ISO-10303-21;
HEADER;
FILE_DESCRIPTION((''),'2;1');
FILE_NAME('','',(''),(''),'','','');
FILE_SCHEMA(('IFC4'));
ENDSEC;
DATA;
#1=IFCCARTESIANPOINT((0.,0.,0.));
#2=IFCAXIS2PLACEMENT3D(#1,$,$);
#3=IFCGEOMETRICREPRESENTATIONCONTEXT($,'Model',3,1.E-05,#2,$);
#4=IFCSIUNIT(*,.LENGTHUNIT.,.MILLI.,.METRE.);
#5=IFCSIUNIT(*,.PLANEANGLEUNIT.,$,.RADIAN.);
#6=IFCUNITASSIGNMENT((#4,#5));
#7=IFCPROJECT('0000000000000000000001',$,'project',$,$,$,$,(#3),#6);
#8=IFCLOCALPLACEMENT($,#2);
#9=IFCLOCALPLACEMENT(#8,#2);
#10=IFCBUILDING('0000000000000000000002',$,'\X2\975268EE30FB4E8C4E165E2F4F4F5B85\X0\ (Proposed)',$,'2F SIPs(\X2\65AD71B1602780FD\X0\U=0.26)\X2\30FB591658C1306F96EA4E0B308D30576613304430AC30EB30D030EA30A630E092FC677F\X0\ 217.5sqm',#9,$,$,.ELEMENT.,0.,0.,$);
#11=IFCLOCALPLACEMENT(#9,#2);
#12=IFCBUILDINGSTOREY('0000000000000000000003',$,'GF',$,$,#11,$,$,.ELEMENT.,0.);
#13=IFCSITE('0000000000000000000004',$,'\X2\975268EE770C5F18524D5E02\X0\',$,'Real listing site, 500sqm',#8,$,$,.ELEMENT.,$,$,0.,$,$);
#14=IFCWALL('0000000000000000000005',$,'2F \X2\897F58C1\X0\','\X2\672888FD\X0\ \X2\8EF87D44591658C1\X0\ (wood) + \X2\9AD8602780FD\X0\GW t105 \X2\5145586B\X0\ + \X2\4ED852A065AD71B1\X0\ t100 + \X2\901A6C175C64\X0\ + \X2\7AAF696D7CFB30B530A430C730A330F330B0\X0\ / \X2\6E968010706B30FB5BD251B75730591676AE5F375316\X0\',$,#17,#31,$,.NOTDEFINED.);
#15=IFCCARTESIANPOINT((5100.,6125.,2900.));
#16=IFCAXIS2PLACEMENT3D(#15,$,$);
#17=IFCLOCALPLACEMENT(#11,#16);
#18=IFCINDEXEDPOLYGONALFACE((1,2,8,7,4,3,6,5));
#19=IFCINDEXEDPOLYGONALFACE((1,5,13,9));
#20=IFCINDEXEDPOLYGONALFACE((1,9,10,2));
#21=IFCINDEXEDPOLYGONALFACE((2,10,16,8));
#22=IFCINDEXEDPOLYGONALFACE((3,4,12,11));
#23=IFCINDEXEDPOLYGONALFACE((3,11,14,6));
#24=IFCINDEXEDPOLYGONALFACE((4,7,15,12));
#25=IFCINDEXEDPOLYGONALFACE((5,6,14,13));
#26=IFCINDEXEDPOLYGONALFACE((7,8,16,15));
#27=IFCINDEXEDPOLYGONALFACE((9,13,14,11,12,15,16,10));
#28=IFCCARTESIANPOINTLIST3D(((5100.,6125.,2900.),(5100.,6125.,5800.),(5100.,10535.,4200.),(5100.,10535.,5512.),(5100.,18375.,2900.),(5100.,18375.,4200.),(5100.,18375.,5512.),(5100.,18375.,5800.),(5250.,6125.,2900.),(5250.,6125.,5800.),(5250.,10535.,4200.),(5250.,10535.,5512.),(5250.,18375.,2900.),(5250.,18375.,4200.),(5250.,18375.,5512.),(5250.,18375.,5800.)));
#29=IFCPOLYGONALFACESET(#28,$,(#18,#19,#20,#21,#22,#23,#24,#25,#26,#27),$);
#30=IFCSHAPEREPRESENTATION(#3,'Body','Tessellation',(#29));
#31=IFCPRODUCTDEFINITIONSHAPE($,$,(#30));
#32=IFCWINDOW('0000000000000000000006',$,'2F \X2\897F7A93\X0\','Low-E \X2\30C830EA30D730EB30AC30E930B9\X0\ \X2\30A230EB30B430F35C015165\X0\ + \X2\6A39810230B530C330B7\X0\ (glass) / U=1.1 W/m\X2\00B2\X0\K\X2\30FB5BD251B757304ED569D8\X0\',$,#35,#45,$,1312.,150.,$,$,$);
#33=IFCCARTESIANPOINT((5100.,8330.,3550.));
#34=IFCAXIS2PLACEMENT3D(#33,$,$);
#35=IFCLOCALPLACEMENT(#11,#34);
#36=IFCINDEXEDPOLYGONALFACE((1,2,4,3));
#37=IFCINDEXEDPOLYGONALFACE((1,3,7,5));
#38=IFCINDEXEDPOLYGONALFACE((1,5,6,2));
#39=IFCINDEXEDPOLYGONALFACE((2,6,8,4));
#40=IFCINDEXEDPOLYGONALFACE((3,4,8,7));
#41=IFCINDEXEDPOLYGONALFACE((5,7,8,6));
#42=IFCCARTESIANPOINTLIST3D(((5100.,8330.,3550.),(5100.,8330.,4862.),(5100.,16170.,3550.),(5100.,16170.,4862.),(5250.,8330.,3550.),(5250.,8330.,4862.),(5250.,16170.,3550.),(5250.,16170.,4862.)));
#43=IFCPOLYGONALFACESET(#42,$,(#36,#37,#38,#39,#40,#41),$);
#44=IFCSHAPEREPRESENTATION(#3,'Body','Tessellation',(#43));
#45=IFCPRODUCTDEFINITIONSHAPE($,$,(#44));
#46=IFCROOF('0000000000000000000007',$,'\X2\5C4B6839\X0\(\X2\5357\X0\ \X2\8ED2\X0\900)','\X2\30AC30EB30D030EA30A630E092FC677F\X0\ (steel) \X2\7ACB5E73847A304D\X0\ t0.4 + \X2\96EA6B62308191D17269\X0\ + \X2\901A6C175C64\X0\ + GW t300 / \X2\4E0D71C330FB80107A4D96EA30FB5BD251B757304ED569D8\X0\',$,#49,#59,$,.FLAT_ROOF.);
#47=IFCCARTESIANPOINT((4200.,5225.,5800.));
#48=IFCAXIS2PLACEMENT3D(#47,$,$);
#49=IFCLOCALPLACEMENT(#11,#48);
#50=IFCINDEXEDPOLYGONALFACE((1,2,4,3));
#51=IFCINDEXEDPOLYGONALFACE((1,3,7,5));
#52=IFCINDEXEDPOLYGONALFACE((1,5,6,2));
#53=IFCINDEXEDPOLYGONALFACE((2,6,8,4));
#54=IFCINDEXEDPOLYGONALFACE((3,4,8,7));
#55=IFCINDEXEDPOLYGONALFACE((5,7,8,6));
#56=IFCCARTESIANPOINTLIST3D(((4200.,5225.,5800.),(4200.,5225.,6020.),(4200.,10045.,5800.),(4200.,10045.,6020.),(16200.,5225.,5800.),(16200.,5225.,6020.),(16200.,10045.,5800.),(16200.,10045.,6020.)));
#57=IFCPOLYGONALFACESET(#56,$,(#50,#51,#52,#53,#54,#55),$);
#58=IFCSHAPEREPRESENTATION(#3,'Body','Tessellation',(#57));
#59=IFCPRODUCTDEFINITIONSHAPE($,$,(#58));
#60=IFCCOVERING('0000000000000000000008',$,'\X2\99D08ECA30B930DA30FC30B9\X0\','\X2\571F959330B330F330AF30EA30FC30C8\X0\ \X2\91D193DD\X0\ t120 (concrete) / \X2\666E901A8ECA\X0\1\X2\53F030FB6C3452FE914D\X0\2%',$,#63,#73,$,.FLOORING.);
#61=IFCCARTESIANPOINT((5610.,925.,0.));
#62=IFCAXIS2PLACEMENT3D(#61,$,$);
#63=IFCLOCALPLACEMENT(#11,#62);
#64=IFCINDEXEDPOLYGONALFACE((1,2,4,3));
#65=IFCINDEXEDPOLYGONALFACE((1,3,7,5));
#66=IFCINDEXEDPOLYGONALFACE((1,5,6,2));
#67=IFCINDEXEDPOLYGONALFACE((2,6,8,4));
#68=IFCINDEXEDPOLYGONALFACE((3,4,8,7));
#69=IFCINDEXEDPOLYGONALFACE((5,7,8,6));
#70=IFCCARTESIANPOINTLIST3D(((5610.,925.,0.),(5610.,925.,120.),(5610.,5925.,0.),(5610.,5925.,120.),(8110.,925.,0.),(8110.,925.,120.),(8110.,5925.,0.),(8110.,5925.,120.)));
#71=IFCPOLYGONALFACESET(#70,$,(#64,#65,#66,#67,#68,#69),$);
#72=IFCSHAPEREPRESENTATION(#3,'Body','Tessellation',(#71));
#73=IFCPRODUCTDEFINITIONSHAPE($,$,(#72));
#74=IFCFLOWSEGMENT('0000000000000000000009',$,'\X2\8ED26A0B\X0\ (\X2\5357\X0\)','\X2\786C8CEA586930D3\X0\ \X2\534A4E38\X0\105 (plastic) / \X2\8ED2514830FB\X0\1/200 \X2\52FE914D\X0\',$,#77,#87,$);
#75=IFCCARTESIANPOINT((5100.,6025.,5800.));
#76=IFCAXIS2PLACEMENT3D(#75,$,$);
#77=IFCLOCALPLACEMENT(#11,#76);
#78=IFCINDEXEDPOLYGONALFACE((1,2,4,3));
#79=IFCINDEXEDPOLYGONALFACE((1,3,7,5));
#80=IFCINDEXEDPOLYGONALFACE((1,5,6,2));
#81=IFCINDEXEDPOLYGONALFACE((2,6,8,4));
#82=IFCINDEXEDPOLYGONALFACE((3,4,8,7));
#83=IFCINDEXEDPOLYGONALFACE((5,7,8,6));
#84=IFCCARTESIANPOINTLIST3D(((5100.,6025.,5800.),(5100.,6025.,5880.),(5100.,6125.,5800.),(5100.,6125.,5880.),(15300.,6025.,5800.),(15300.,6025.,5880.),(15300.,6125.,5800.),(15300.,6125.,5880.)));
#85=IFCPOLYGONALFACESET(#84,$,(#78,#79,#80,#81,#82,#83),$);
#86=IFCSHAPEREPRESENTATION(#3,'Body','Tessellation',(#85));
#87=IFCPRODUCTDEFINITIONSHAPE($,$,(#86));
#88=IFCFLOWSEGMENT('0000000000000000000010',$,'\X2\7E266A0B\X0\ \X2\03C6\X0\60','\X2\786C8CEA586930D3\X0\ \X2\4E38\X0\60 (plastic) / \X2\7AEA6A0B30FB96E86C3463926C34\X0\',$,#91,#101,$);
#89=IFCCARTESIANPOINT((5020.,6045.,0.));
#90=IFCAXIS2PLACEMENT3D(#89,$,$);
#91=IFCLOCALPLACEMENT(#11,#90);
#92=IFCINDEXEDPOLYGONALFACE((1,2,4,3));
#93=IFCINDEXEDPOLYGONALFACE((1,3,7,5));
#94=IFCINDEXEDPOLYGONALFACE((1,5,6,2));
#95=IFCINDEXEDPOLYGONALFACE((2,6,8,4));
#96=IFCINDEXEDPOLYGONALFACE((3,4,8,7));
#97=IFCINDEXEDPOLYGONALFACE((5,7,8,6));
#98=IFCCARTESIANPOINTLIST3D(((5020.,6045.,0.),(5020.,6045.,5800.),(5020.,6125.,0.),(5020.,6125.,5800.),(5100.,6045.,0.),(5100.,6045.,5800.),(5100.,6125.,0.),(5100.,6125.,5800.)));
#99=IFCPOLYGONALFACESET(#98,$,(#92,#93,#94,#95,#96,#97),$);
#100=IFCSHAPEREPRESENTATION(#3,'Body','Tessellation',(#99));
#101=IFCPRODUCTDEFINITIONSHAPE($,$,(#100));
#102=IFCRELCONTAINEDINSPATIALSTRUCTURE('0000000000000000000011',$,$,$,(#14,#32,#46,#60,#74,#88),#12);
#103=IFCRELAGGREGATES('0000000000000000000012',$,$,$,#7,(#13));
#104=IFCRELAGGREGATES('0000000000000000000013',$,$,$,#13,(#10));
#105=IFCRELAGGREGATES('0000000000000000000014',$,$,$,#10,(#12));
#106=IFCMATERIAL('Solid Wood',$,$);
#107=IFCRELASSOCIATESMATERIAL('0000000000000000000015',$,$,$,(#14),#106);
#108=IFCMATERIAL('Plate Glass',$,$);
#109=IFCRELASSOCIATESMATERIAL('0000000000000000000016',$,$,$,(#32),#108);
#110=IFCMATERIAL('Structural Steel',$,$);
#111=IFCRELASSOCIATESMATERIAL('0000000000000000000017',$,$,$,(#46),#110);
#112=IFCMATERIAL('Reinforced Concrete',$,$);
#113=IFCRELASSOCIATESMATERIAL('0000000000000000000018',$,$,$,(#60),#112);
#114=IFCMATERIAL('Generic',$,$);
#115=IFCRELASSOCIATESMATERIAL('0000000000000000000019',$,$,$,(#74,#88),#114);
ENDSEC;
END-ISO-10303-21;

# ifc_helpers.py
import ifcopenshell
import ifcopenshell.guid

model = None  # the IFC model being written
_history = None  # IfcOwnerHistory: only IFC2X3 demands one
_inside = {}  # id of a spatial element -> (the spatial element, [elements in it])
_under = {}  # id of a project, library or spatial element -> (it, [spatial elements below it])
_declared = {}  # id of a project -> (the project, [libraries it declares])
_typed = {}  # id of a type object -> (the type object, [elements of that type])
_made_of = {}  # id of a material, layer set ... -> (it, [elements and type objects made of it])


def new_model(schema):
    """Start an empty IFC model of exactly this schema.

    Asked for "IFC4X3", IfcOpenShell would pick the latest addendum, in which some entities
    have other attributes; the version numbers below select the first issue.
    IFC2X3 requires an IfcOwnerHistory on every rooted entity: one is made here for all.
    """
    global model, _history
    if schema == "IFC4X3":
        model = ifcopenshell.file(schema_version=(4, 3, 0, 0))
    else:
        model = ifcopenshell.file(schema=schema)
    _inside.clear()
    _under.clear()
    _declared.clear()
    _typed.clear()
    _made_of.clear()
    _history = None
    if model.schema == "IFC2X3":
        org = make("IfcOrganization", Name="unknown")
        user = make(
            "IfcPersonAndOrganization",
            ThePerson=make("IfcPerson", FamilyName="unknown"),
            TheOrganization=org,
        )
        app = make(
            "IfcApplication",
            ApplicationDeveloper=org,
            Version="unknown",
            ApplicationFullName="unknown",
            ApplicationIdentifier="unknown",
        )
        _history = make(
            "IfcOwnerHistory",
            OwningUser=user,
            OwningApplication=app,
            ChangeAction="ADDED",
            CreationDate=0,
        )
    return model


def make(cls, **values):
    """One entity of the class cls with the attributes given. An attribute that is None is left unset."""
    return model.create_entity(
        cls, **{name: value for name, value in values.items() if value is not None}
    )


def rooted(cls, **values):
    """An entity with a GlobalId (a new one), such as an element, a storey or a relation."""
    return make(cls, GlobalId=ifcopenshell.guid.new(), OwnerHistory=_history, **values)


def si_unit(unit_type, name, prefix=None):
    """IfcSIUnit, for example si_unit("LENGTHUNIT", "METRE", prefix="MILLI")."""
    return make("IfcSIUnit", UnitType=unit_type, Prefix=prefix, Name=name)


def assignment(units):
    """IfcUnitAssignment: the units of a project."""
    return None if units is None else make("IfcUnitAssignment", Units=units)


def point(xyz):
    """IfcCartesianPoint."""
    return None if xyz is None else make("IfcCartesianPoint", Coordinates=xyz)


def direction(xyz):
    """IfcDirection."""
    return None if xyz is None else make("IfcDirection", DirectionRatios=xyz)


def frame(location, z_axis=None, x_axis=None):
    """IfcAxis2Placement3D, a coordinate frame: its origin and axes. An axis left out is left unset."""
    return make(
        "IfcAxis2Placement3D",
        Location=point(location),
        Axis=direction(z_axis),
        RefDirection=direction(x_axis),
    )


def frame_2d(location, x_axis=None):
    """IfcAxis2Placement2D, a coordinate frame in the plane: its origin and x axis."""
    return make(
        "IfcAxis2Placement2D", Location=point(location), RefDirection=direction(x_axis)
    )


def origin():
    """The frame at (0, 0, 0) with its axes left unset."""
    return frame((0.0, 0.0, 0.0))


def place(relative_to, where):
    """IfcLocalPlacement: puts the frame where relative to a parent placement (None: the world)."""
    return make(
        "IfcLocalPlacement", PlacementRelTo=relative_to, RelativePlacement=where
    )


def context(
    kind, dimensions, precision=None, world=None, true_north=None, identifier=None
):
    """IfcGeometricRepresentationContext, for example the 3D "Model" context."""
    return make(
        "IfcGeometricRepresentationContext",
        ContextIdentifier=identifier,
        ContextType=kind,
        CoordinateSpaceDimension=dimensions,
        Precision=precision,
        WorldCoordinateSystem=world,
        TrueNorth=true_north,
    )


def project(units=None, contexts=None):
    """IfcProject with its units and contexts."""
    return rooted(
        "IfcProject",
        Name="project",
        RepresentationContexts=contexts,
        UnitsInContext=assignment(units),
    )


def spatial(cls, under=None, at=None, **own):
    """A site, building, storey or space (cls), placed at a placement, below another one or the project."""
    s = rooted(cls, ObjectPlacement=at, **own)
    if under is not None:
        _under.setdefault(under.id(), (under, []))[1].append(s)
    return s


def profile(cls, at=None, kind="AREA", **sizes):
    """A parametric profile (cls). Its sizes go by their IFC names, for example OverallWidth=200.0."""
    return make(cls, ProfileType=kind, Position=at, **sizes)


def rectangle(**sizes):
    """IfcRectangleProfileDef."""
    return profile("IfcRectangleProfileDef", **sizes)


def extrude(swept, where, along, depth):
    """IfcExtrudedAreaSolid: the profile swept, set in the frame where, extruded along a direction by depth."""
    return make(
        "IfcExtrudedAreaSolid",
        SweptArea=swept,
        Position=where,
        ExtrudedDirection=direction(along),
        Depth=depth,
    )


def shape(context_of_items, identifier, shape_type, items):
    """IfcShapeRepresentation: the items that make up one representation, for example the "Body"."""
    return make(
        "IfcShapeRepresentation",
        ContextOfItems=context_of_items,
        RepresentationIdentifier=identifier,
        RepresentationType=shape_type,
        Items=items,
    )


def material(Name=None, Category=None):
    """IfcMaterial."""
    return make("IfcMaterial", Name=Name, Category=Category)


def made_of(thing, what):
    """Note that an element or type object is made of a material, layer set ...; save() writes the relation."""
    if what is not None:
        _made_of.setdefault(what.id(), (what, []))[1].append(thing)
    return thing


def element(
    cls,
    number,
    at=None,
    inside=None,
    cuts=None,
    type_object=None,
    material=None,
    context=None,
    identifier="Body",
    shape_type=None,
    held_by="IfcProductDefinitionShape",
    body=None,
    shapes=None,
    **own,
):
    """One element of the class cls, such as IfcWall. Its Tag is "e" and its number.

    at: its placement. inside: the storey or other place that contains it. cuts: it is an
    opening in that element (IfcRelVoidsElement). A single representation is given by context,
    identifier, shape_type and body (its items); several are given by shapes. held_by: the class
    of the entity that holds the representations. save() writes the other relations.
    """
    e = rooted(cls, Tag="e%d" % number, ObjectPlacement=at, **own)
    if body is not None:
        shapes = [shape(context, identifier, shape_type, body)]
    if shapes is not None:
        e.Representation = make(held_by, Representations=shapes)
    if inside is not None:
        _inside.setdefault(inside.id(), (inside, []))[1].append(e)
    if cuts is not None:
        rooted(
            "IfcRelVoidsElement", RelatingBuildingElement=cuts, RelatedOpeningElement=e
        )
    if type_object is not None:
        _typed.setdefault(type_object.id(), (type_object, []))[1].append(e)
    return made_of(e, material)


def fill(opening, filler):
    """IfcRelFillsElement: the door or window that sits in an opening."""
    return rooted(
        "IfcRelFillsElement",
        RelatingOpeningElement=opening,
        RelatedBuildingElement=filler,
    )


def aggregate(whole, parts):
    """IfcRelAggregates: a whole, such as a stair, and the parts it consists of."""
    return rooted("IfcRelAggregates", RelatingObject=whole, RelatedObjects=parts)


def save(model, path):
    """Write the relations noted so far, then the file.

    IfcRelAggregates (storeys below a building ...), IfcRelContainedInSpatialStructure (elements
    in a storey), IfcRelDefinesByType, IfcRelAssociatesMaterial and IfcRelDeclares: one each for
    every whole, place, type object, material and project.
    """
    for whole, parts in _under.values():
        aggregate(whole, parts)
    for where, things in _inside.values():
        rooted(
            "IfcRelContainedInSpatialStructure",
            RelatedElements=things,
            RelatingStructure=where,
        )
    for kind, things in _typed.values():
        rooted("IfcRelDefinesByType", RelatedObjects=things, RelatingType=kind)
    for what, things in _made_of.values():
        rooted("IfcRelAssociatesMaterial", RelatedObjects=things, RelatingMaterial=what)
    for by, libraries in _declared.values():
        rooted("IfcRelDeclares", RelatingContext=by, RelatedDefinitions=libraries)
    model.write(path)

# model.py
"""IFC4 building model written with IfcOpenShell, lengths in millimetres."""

from ifc_helpers import new_model, si_unit, frame, frame_2d, origin, place, context, project, spatial, rectangle, extrude, material, element, fill, save


model = new_model("IFC4")

# Units and contexts
model_context = context("Model", 3, precision=1e-05, world=origin())
ifc_project = project(units=[si_unit("LENGTHUNIT", "METRE", prefix="MILLI"), si_unit("PLANEANGLEUNIT", "RADIAN")], contexts=[model_context])

# Site, building, storey
site_placement = place(None, origin())
site = spatial("IfcSite", under=ifc_project, at=site_placement, Name="青森県弘前市", ObjectType="Real listing site, 500sqm", CompositionType="ELEMENT", RefElevation=0.0)
building_placement = place(site_placement, origin())
building = spatial("IfcBuilding", under=site, at=building_placement, Name="青森・二世帯住宅 (Proposed)", ObjectType="2F SIPs(断熱性能U=0.26)・外壁は雪下ろし易いガルバリウム鋼板 217.5sqm", CompositionType="ELEMENT", ElevationOfRefHeight=0.0, ElevationOfTerrain=0.0)
storey_placement = place(building_placement, origin())
storey = spatial("IfcBuildingStorey", under=building, at=storey_placement, Name="GF", CompositionType="ELEMENT", Elevation=0.0)

# Shared definitions
ifc_material_1 = material(Name="Solid Wood")

# Shared definitions
ifc_material_2 = material(Name="Reinforced Concrete")

# Shared definitions
ifc_material_3 = material(Name="Plate Glass")

# Wall, opening, window
wall_1_placement = place(storey_placement, frame((5100.0, 6125.0, 2900.0)))
wall_1 = element("IfcWall", 1, at=wall_1_placement, inside=storey, material=ifc_material_1, Name="2F 西壁", Description="木製 軸組外壁 (wood) + 高性能GW t105 充填 + 付加断熱 t100 + 通気層 + 窯業系サイディング / 準耐火・寒冷地外皮強化", PredefinedType="NOTDEFINED", context=model_context, shape_type="SweptSolid", body=[
    extrude(rectangle(XDim=150.0, YDim=12250.0, at=frame_2d((75.0, 6125.0))), frame((5100.0, 6125.0, 2900.0)), (0.0, 0.0, 1.0), 2900.0),
])
opening_1_placement = place(storey_placement, frame((5100.0, 8330.0, 3550.0)))
opening_1 = element("IfcOpeningElement", 2, at=opening_1_placement, cuts=wall_1, PredefinedType="NOTDEFINED", context=model_context, shape_type="SweptSolid", body=[
    extrude(rectangle(XDim=150.0, YDim=7840.0, at=frame_2d((75.0, 3920.0))), frame((5100.0, 8330.0, 3550.0)), (0.0, 0.0, 1.0), 1312.0),
])
window_1_placement = place(storey_placement, frame((5100.0, 8330.0, 3550.0)))
window_1 = element("IfcWindow", 3, at=window_1_placement, inside=storey, material=ifc_material_3, Name="2F 西窓", Description="Low-E トリプルガラス アルゴン封入 + 樹脂サッシ (glass) / U=1.1 W/m²K・寒冷地仕様", OverallHeight=1312.0, OverallWidth=150.0, context=model_context, shape_type="SweptSolid", body=[
    extrude(rectangle(XDim=150.0, YDim=7840.0, at=frame_2d((75.0, 3920.0))), frame((5100.0, 8330.0, 3550.0)), (0.0, 0.0, 1.0), 1312.0),
])
fill(opening_1, window_1)

# Roof
ifc_material_4 = material(Name="Structural Steel")
for number, where, name in (
    (4, (4200.0, 5225.0, 5800.0), "屋根(南 軒900)"),
):
    element("IfcRoof", number, at=place(storey_placement, frame(where)), inside=storey, material=ifc_material_4, Name=name, Description="ガルバリウム鋼板 (steel) 立平葺き t0.4 + 雪止め金物 + 通気層 + GW t300 / 不燃・耐積雪・寒冷地仕様", PredefinedType="FLAT_ROOF", context=model_context, shape_type="SweptSolid", body=[
        extrude(rectangle(XDim=12000.0, YDim=4820.0, at=frame_2d((6000.0, 2410.0))), frame((4200.0, 5225.0, 5800.0)), (0.0, 0.0, 1.0), 220.0),
    ])

# Covering
covering_placement = place(storey_placement, frame((5610.0, 925.0, 0.0)))
element("IfcCovering", 5, at=covering_placement, inside=storey, material=ifc_material_2, Name="駐車スペース", Description="土間コンクリート 金鏝 t120 (concrete) / 普通車1台・水勾配2%", PredefinedType="FLOORING", context=model_context, shape_type="SweptSolid", body=[
    extrude(rectangle(XDim=2500.0, YDim=5000.0, at=frame_2d((1250.0, 2500.0))), frame((5610.0, 925.0, 0.0)), (0.0, 0.0, 1.0), 120.0),
])

# Flow segments
ifc_material_5 = material(Name="Generic")
flow_segment_1_placement = place(storey_placement, frame((5100.0, 6025.0, 5800.0)))
element("IfcFlowSegment", 6, at=flow_segment_1_placement, inside=storey, material=ifc_material_5, Name="軒樋 (南)", Description="硬質塩ビ 半丸105 (plastic) / 軒先・1/200 勾配", context=model_context, shape_type="SweptSolid", body=[
    extrude(rectangle(XDim=10200.0, YDim=100.0, at=frame_2d((5100.0, 50.0))), frame((5100.0, 6025.0, 5800.0)), (0.0, 0.0, 1.0), 80.0),
])
flow_segment_2_placement = place(storey_placement, frame((5020.0, 6045.0, 0.0)))
element("IfcFlowSegment", 7, at=flow_segment_2_placement, inside=storey, material=ifc_material_5, Name="縦樋 φ60", Description="硬質塩ビ 丸60 (plastic) / 竪樋・雨水排水", context=model_context, shape_type="SweptSolid", body=[
    extrude(rectangle(XDim=80.0, YDim=80.0, at=frame_2d((40.0, 40.0))), frame((5020.0, 6045.0, 0.0)), (0.0, 0.0, 1.0), 5800.0),
])

save(model, "model.ifc")
